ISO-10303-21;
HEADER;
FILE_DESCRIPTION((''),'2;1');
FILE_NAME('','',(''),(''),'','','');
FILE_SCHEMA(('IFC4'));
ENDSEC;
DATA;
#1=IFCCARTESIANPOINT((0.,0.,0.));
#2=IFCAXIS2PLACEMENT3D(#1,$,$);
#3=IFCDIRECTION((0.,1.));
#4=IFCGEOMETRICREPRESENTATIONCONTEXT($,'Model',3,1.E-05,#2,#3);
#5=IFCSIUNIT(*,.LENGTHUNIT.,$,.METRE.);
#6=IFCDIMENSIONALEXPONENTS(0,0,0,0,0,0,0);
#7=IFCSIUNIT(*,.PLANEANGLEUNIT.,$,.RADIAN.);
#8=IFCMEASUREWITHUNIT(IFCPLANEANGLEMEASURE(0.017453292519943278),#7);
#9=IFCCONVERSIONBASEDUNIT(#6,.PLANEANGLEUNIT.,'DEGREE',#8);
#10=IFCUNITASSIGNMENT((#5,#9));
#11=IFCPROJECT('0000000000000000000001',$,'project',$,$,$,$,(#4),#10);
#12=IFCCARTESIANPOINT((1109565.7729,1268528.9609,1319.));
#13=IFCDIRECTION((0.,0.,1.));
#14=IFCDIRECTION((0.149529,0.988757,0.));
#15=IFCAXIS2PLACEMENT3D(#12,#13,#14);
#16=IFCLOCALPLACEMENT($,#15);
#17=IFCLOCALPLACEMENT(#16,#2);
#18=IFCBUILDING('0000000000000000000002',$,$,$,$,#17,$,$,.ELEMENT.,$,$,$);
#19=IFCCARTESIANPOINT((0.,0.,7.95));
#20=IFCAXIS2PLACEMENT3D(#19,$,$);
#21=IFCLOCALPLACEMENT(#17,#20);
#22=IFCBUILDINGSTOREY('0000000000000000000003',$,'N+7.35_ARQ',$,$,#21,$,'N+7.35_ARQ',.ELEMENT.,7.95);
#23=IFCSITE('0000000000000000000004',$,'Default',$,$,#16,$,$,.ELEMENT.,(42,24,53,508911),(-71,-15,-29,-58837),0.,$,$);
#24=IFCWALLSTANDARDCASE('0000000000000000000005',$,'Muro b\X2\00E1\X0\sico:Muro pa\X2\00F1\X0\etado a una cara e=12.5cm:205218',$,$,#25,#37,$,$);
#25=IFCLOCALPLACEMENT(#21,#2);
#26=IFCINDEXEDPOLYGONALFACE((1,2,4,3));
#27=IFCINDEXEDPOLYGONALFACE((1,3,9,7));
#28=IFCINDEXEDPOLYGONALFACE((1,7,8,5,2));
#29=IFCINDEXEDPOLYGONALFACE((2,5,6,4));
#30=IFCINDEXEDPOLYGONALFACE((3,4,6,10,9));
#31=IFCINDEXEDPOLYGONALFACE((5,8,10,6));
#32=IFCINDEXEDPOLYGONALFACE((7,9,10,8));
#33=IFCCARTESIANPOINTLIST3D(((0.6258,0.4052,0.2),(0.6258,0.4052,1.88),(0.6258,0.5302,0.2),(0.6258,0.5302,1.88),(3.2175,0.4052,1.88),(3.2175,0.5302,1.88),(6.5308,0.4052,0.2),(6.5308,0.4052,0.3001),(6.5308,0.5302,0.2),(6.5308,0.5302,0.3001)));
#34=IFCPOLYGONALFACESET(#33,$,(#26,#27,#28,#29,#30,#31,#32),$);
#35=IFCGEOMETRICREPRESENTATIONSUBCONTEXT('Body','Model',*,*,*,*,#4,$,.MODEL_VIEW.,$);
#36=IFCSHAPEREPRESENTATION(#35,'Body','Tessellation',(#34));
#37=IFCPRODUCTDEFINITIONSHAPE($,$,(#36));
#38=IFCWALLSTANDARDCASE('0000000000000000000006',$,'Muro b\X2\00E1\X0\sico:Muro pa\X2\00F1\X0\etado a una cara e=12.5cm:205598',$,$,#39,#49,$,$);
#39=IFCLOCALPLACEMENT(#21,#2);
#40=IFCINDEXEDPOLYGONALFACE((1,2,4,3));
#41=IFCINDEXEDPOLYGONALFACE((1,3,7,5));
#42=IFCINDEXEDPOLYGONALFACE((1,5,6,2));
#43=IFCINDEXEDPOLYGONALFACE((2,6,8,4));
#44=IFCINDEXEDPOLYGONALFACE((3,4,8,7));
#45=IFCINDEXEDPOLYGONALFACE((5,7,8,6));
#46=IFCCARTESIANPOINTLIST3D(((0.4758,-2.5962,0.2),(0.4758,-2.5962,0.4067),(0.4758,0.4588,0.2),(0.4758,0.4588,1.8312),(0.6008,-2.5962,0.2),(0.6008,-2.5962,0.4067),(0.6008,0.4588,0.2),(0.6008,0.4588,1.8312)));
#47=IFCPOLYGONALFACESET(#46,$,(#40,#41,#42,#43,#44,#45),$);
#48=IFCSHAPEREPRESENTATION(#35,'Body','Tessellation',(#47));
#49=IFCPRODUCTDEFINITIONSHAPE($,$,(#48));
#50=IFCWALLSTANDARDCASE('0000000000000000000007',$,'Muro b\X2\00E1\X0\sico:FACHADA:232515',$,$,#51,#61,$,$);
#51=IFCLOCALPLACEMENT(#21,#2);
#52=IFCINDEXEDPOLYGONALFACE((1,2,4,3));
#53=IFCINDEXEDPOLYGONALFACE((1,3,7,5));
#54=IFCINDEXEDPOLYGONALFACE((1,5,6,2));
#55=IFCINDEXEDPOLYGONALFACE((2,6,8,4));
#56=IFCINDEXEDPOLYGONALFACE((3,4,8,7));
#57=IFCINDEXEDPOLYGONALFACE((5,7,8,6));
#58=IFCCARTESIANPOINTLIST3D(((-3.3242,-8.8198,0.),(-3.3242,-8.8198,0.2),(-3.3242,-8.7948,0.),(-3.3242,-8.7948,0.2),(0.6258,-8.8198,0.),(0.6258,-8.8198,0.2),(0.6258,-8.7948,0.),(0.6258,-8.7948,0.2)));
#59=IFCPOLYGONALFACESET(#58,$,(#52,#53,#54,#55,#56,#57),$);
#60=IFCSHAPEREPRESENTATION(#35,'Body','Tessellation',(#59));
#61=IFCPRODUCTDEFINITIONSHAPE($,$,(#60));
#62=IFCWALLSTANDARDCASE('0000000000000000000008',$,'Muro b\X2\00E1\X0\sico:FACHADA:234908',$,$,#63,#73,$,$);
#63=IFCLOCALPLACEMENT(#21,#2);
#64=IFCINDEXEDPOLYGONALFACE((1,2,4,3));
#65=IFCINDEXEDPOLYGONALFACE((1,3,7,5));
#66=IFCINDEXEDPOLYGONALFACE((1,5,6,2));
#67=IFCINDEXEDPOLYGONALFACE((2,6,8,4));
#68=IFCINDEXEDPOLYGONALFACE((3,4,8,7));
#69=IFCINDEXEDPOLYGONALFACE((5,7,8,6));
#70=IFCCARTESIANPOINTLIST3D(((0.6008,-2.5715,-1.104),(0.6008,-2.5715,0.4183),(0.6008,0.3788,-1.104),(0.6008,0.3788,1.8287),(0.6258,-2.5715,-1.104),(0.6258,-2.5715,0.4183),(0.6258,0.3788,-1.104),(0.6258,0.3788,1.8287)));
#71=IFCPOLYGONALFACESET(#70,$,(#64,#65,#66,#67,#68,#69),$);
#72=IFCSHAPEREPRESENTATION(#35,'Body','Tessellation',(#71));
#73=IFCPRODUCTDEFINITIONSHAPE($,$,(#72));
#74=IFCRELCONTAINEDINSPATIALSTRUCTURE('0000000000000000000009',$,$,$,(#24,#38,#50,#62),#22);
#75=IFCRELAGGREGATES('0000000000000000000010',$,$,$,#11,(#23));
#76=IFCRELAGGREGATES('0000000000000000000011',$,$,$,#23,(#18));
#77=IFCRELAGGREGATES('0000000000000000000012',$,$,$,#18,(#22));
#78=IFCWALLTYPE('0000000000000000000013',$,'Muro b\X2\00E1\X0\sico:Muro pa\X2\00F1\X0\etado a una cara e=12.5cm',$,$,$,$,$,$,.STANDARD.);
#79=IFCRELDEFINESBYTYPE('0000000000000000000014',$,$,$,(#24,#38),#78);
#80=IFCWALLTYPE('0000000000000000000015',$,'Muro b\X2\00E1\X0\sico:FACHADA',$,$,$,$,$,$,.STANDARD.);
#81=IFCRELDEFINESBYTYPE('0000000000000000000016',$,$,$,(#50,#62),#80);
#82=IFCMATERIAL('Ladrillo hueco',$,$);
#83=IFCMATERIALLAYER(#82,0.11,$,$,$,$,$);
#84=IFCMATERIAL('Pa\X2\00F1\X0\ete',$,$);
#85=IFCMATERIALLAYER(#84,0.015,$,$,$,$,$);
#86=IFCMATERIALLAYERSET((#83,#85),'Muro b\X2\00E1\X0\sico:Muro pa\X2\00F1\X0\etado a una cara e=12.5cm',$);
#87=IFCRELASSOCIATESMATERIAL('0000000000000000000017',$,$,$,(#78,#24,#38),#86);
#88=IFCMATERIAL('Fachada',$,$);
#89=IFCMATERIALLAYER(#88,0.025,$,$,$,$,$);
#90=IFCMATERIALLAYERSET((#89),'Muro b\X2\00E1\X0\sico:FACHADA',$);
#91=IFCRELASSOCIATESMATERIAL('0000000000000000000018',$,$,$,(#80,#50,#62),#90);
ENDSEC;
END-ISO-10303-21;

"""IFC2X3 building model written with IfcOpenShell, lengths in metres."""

from ifc_helpers import new_model, entity, si_unit, converted_unit, direction, frame, frame_2d, origin, place, context, subcontext, project, spatial, rectangle, extrude, clip, halfspace, material, layer, layer_set, layer_usage, type_object, element, save


model = new_model("IFC2X3")

# Units and contexts
model_context = context("Model", 3, precision=1e-05, world=origin(), true_north=direction((0.0, 1.0)))
body_context = subcontext(model_context, "Body", "Model", "MODEL_VIEW")
ifc_project = project(units=[si_unit("LENGTHUNIT", "METRE"), converted_unit("PLANEANGLEUNIT", "DEGREE", entity("IfcPlaneAngleMeasure", 0.017453292519943278), si_unit("PLANEANGLEUNIT", "RADIAN"), dimensions=[0, 0, 0, 0, 0, 0, 0])], contexts=[model_context])

# Site, building, storey
site_placement = place(None, frame((1109565.7729, 1268528.9609, 1319.0), z_axis=(0.0, 0.0, 1.0), x_axis=(0.149529, 0.988757, 0.0)))
site = spatial("IfcSite", under=ifc_project, at=site_placement, Name="Default", CompositionType="ELEMENT", RefLatitude=(42, 24, 53, 508911), RefLongitude=(-71, -15, -29, -58837), RefElevation=0.0)
building_placement = place(site_placement, origin())
building = spatial("IfcBuilding", under=site, at=building_placement, CompositionType="ELEMENT")
storey_placement = place(building_placement, frame((0.0, 0.0, 7.95)))
storey = spatial("IfcBuildingStorey", under=building, at=storey_placement, Name="N+7.35_ARQ", LongName="N+7.35_ARQ", CompositionType="ELEMENT", Elevation=7.95)

# Walls
ifc_material_1 = material(Name="Ladrillo hueco")
ifc_layer_1 = layer(ifc_material_1, 0.11)
ifc_material_2 = material(Name="Pañete")
ifc_layer_2 = layer(ifc_material_2, 0.015)
ifc_layer_set_1 = layer_set([ifc_layer_1, ifc_layer_2], Name="Muro básico:Muro pañetado a una cara e=12.5cm")
ifc_layer_usage_1 = layer_usage(ifc_layer_set_1, "AXIS2", "NEGATIVE", 0.0625)
wall_type_1 = type_object("IfcWallType", Name="Muro básico:Muro pañetado a una cara e=12.5cm", PredefinedType="STANDARD", material=ifc_layer_set_1)
wall_1_placement = place(storey_placement, frame((6.5308, 0.4677, 0.2), z_axis=(0.0, 0.0, 1.0), x_axis=(-1.0, 0.0, 0.0)))
element("IfcWallStandardCase", 1, at=wall_1_placement, inside=storey, type_object=wall_type_1, material=ifc_layer_usage_1, Name="Muro básico:Muro pañetado a una cara e=12.5cm:205218", context=body_context, shape_type="Clipping", body=[
    clip(clip(extrude(rectangle(XDim=5.905, YDim=0.125, at=frame_2d((2.9525, 0.0), x_axis=(-1.0, 0.0))), origin(), (0.0, 0.0, 1.0), 1.68), halfspace(frame((0.0, -0.0625, 0.1001), z_axis=(-0.430421, 0.0, 0.902628), x_axis=(0.0, 1.0, 0.0)), False)), halfspace(frame((3.3132, -0.0625, 1.68), z_axis=(0.0, 0.0, 1.0), x_axis=(0.0, 1.0, 0.0)), False)),
])
ifc_layer_usage_2 = layer_usage(ifc_layer_set_1, "AXIS2", "NEGATIVE", 0.0625)
wall_2_placement = place(storey_placement, frame((0.5383, 0.4588, 0.2), z_axis=(0.0, 0.0, 1.0), x_axis=(0.0, -1.0, 0.0)))
element("IfcWallStandardCase", 2, at=wall_2_placement, inside=storey, type_object=wall_type_1, material=ifc_layer_usage_2, Name="Muro básico:Muro pañetado a una cara e=12.5cm:205598", context=body_context, shape_type="Clipping", body=[
    clip(extrude(rectangle(XDim=3.055, YDim=0.125, at=frame_2d((1.5275, 0.0), x_axis=(-1.0, 0.0))), origin(), (0.0, 0.0, 1.0), 1.6312), halfspace(frame((0.0, -0.0625, 1.6312), z_axis=(0.422613, 0.0, 0.90631), x_axis=(0.0, 1.0, 0.0)), False)),
])
ifc_material_3 = material(Name="Fachada")
ifc_layer_3 = layer(ifc_material_3, 0.025)
ifc_layer_set_2 = layer_set([ifc_layer_3], Name="Muro básico:FACHADA")
ifc_layer_usage_3 = layer_usage(ifc_layer_set_2, "AXIS2", "POSITIVE", -0.0125)
wall_type_2 = type_object("IfcWallType", Name="Muro básico:FACHADA", PredefinedType="STANDARD", material=ifc_layer_set_2)
wall_3_placement = place(storey_placement, frame((-3.3242, -8.8073, 0.0)))
element("IfcWallStandardCase", 3, at=wall_3_placement, inside=storey, type_object=wall_type_2, material=ifc_layer_usage_3, Name="Muro básico:FACHADA:232515", context=body_context, shape_type="SweptSolid", body=[
    extrude(rectangle(XDim=3.95, YDim=0.025, at=frame_2d((1.975, 0.0), x_axis=(-1.0, 0.0))), origin(), (0.0, 0.0, 1.0), 0.2),
])
ifc_layer_usage_4 = layer_usage(ifc_layer_set_2, "AXIS2", "POSITIVE", -0.0125)
wall_4_placement = place(storey_placement, frame((0.6133, -2.5715, -1.104), z_axis=(0.0, 0.0, 1.0), x_axis=(0.0, 1.0, 0.0)))
element("IfcWallStandardCase", 4, at=wall_4_placement, inside=storey, type_object=wall_type_2, material=ifc_layer_usage_4, Name="Muro básico:FACHADA:234908", context=body_context, shape_type="Clipping", body=[
    clip(extrude(rectangle(XDim=2.9503, YDim=0.025, at=frame_2d((1.4751, 0.0), x_axis=(-1.0, 0.0))), origin(), (0.0, 0.0, 1.0), 2.9327), halfspace(frame((0.0, -0.0125, 1.5223), z_axis=(-0.431304, 0.0, 0.902207), x_axis=(0.0, 1.0, 0.0)), False)),
])

save(model, "model.ifc")
